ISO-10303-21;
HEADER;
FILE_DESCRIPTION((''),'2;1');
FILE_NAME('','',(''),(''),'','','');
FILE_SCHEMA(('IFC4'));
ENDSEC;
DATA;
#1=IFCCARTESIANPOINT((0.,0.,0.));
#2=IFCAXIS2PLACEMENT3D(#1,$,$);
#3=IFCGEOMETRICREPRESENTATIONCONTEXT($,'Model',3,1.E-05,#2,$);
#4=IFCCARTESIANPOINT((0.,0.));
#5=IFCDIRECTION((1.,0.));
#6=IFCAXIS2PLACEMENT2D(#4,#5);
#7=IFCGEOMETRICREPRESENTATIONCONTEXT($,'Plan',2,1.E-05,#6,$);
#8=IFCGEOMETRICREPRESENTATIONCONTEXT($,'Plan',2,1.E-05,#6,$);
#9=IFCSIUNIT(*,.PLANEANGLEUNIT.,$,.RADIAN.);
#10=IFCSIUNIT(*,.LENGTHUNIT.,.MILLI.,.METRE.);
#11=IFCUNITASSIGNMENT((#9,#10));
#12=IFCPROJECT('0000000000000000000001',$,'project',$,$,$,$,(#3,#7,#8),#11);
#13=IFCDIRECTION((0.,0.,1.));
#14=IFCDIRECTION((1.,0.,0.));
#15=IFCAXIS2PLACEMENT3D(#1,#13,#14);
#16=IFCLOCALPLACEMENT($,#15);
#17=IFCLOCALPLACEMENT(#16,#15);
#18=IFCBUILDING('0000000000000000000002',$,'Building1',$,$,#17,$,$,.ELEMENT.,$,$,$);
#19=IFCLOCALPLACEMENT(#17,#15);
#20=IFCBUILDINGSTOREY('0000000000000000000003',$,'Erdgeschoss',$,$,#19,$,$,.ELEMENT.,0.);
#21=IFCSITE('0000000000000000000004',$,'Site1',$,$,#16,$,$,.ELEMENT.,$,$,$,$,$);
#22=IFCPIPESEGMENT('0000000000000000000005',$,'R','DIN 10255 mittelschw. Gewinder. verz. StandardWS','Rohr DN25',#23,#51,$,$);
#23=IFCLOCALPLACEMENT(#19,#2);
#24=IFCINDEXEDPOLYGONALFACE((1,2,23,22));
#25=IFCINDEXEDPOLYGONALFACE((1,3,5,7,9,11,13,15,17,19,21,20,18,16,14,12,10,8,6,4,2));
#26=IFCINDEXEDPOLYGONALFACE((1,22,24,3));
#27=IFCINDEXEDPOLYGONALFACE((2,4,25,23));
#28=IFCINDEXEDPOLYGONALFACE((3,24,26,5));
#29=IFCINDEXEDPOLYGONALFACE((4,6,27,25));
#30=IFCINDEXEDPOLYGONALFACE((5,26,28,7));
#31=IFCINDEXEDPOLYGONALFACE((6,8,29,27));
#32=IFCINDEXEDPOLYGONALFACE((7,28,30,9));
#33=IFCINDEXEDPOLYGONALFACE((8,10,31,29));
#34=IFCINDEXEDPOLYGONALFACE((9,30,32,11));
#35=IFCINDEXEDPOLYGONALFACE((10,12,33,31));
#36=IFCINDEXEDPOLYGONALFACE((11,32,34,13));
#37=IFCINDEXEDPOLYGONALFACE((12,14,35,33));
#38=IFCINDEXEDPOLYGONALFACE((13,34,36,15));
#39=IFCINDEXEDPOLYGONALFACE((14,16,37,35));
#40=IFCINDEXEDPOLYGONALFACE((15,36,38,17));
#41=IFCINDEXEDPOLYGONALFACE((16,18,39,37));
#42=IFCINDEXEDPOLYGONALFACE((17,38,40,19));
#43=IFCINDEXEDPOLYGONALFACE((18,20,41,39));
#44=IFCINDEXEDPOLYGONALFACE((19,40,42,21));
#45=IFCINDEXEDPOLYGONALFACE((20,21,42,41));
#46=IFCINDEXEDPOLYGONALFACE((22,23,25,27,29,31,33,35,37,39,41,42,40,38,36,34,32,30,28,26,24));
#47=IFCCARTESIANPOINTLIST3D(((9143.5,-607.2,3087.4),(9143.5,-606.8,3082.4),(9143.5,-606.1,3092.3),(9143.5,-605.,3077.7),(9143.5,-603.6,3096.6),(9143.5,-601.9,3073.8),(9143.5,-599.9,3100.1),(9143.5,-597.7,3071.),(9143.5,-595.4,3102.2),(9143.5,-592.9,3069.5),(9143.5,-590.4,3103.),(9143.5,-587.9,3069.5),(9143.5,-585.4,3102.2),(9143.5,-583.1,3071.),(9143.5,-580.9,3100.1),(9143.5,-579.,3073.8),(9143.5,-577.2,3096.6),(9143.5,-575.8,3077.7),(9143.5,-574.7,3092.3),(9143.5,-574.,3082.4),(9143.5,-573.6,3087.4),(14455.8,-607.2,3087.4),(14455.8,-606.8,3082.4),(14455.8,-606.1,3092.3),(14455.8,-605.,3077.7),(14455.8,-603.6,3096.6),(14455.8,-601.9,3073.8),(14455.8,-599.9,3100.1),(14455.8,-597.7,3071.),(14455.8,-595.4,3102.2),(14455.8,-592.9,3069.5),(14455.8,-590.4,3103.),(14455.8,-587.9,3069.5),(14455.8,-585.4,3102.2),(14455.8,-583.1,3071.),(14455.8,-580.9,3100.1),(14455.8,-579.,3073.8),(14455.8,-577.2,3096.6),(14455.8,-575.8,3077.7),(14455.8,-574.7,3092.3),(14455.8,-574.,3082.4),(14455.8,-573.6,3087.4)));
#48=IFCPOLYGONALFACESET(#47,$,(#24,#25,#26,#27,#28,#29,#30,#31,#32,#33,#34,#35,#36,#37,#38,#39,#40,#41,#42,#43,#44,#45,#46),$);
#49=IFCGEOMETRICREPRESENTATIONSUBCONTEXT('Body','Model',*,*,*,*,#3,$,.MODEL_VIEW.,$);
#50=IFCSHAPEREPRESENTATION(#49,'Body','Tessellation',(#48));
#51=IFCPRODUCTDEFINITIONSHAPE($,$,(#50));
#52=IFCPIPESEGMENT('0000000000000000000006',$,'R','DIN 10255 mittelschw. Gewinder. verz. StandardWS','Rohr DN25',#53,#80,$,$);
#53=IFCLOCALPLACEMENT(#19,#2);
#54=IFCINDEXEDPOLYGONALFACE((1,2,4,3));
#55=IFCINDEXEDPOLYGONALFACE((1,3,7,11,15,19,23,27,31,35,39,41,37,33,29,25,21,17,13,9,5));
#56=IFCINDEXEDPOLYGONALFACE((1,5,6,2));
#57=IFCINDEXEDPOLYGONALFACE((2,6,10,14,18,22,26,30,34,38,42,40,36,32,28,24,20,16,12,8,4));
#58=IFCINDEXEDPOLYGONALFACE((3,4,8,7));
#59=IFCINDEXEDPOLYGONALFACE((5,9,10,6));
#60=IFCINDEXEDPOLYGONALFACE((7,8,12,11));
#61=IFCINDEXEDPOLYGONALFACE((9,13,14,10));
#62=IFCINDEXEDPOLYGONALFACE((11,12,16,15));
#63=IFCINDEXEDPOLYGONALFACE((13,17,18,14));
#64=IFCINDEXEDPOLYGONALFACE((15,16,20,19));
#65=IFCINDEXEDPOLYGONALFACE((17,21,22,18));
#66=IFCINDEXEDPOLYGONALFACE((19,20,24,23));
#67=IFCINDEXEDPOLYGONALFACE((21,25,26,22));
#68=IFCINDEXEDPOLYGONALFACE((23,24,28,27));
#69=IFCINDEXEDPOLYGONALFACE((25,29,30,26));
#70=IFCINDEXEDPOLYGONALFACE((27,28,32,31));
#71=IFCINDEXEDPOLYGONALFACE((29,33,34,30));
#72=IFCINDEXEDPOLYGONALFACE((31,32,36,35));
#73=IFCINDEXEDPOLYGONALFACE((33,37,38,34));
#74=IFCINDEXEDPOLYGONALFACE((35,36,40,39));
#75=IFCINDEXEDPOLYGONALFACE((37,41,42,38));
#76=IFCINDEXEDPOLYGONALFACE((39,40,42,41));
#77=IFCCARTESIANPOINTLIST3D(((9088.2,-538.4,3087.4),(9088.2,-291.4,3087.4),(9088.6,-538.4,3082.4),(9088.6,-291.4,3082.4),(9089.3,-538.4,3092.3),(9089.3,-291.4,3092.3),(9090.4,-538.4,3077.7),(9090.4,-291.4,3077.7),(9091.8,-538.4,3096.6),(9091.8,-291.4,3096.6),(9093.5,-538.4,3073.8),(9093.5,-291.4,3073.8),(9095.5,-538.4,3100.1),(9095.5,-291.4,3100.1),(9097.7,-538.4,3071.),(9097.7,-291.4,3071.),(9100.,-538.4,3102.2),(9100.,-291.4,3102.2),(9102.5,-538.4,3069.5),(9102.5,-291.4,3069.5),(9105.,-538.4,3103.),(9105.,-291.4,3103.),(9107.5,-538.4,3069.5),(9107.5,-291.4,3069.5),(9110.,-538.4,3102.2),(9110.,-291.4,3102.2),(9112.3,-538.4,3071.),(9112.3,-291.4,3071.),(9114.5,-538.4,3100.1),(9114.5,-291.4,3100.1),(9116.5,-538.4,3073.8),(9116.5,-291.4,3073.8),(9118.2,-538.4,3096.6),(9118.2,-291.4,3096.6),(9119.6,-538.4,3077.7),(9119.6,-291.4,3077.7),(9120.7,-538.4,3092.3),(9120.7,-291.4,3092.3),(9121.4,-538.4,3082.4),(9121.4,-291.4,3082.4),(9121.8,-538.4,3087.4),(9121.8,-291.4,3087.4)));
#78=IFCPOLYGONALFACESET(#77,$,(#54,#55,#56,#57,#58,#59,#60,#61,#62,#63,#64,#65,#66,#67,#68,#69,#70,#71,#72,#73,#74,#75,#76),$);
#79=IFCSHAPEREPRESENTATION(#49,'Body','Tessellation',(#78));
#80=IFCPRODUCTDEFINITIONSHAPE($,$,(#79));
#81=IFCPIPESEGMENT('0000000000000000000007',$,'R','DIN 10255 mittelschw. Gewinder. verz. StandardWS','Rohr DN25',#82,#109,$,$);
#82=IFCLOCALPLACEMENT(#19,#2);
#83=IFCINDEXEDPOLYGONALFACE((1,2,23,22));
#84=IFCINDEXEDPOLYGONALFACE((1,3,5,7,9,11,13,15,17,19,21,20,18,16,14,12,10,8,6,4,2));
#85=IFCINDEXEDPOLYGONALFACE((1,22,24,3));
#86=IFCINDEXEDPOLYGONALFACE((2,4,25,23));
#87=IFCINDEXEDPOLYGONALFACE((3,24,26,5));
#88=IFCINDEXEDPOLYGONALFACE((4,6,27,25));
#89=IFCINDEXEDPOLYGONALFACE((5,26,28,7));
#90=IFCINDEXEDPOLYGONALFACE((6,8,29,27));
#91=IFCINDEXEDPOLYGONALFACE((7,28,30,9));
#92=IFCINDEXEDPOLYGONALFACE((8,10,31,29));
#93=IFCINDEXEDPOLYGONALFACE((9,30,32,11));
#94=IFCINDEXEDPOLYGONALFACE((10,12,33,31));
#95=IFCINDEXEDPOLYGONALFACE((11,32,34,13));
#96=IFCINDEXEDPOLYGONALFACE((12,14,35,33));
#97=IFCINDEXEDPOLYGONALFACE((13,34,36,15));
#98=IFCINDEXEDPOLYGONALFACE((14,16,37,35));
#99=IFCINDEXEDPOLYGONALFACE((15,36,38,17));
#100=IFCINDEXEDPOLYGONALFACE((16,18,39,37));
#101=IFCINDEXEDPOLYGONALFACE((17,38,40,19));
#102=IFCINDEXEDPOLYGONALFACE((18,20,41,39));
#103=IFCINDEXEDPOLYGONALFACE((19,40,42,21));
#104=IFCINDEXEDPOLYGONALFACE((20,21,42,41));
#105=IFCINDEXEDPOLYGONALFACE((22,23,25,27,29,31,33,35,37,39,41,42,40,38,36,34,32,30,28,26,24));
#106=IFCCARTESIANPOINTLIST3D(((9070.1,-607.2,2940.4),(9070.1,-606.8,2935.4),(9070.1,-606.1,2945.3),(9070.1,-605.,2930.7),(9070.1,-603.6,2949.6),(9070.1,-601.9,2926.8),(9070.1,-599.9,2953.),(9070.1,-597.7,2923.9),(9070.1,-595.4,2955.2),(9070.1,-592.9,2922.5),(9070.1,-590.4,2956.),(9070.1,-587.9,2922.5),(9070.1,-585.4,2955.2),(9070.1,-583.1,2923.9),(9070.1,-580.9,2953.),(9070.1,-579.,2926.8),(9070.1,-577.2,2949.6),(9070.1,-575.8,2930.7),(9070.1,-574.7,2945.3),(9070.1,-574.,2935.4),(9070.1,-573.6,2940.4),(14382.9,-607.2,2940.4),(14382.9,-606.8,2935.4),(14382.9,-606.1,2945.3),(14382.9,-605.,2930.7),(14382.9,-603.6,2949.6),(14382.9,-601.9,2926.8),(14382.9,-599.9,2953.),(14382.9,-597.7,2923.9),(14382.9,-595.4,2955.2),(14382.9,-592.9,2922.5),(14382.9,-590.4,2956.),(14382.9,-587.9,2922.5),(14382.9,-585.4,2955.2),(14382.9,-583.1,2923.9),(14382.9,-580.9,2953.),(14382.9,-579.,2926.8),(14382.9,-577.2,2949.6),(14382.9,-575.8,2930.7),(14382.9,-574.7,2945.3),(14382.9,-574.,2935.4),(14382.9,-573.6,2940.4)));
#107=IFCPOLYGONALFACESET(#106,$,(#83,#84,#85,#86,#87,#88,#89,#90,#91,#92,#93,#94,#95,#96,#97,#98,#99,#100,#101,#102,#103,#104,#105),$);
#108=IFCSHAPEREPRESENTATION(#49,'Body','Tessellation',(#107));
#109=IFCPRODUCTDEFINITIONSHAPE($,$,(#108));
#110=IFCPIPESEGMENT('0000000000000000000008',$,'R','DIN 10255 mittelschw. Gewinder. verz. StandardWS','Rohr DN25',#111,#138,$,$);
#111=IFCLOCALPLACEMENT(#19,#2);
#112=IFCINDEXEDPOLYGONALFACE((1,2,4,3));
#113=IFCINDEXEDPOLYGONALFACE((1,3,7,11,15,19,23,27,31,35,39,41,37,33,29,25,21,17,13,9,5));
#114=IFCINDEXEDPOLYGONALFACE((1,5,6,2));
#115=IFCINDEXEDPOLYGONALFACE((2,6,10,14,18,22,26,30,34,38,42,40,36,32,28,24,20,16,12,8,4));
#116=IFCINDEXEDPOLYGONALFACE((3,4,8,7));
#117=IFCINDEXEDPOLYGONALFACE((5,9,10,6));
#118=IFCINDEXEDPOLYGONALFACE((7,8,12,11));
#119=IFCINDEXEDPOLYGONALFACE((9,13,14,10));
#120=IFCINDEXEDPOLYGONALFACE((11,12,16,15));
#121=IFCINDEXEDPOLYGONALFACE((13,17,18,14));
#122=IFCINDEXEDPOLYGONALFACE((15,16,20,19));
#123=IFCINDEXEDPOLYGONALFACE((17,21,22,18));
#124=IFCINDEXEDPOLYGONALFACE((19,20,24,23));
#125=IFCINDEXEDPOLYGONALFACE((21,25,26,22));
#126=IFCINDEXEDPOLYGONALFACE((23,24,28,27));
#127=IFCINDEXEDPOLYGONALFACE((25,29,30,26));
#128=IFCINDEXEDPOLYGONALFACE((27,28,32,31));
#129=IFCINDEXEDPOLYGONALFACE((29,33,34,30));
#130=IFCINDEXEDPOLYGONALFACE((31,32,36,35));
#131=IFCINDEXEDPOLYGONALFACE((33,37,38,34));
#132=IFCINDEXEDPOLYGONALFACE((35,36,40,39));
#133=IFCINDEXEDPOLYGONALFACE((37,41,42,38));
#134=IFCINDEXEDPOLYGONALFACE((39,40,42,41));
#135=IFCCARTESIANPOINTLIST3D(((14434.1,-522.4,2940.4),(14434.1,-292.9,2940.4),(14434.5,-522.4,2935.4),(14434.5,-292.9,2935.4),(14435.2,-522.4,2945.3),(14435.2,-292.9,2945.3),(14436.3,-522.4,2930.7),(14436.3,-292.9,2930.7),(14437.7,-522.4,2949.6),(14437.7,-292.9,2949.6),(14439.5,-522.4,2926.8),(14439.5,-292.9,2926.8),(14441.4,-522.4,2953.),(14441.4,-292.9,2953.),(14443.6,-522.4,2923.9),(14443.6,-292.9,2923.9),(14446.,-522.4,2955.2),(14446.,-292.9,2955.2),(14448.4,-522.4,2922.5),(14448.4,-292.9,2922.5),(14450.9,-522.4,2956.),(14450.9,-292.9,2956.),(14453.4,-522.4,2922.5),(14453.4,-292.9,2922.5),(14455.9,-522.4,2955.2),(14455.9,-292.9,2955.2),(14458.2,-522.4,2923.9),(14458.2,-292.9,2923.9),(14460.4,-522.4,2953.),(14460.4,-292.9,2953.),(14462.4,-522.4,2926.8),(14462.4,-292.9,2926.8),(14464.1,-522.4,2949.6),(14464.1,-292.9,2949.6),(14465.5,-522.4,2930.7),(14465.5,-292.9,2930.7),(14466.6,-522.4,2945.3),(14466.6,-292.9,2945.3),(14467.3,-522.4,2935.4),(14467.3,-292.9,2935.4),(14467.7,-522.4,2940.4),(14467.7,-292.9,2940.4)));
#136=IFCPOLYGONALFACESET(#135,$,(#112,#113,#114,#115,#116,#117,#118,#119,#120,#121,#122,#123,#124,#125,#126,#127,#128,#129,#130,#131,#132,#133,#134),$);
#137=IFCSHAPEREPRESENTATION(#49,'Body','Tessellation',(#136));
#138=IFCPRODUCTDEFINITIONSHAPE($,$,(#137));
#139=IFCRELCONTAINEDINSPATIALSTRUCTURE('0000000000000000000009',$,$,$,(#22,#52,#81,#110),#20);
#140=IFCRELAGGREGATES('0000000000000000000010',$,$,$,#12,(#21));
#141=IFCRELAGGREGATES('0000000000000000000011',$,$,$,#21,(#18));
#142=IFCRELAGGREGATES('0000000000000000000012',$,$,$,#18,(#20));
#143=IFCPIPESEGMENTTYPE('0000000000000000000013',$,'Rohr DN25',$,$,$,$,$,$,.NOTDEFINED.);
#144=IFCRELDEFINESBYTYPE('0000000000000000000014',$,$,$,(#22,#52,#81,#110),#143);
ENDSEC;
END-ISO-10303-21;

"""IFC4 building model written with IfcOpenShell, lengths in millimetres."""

from ifc_helpers import new_model, si_unit, frame, origin, origin_with_axes, origin_2d_with_axis, place, context, subcontext, project, spatial, circle, extrude, type_object, element, save


model = new_model("IFC4")

# Units and contexts
model_context = context("Model", 3, precision=1e-05, world=origin())
plan_context_1 = context("Plan", 2, precision=1e-05, world=origin_2d_with_axis())
plan_context_2 = context("Plan", 2, precision=1e-05, world=origin_2d_with_axis())
body_context = subcontext(model_context, "Body", "Model", "MODEL_VIEW")
ifc_project = project(units=[si_unit("PLANEANGLEUNIT", "RADIAN"), si_unit("LENGTHUNIT", "METRE", prefix="MILLI")], contexts=[model_context, plan_context_1, plan_context_2])

# Site, building, storey
site_placement = place(None, origin_with_axes())
site = spatial("IfcSite", under=ifc_project, at=site_placement, Name="Site1", CompositionType="ELEMENT")
building_placement = place(site_placement, origin_with_axes())
building = spatial("IfcBuilding", under=site, at=building_placement, Name="Building1", CompositionType="ELEMENT")
storey_placement = place(building_placement, origin_with_axes())
storey = spatial("IfcBuildingStorey", under=building, at=storey_placement, Name="Erdgeschoss", CompositionType="ELEMENT", Elevation=0.0)

# Pipe segments
pipe_segment_type_1 = type_object("IfcPipeSegmentType", Name="Rohr DN25", PredefinedType="NOTDEFINED")
pipe_segment_1_placement = place(storey_placement, frame((11799.6, -590.3, 3086.1), z_axis=(0.0, 0.0, 1.0), x_axis=(1.0, 0.0, 0.0)))
element("IfcPipeSegment", 1, at=pipe_segment_1_placement, inside=storey, type_object=pipe_segment_type_1, Name="R", Description="DIN 10255 mittelschw. Gewinder. verz. StandardWS", ObjectType="Rohr DN25", context=body_context, shape_type="SolidModel", body=[
    extrude(circle(Radius=16.9, at=origin_2d_with_axis()), frame((-2656.1, -0.2, 0.0), z_axis=(1.0, 0.0, 0.0), x_axis=(0.0, 0.0, 1.0)), (0.0, 0.0, 1.0), 5312.3),
])
pipe_segment_2_placement = place(storey_placement, frame((9104.8, -414.9, 3086.1), z_axis=(0.0, 0.0, 1.0), x_axis=(1.0, 0.0, 0.0)))
element("IfcPipeSegment", 2, at=pipe_segment_2_placement, inside=storey, type_object=pipe_segment_type_1, Name="R", Description="DIN 10255 mittelschw. Gewinder. verz. StandardWS", ObjectType="Rohr DN25", context=body_context, shape_type="SolidModel", body=[
    extrude(circle(Radius=16.9, at=origin_2d_with_axis()), frame((0.1, -123.5, 0.0), z_axis=(0.0, 1.0, 0.0), x_axis=(0.0, 0.0, 1.0)), (0.0, 0.0, 1.0), 247.0),
])
pipe_segment_3_placement = place(storey_placement, frame((11726.5, -590.3, 2939.1), z_axis=(0.0, 0.0, 1.0), x_axis=(1.0, 0.0, 0.0)))
element("IfcPipeSegment", 3, at=pipe_segment_3_placement, inside=storey, type_object=pipe_segment_type_1, Name="R", Description="DIN 10255 mittelschw. Gewinder. verz. StandardWS", ObjectType="Rohr DN25", context=body_context, shape_type="SolidModel", body=[
    extrude(circle(Radius=16.9, at=origin_2d_with_axis()), frame((-2656.4, -0.2, 0.0), z_axis=(1.0, 0.0, 0.0), x_axis=(0.0, 0.0, 1.0)), (0.0, 0.0, 1.0), 5312.8),
])
pipe_segment_4_placement = place(storey_placement, frame((14450.8, -407.6, 2939.1), z_axis=(0.0, 0.0, 1.0), x_axis=(1.0, 0.0, 0.0)))
element("IfcPipeSegment", 4, at=pipe_segment_4_placement, inside=storey, type_object=pipe_segment_type_1, Name="R", Description="DIN 10255 mittelschw. Gewinder. verz. StandardWS", ObjectType="Rohr DN25", context=body_context, shape_type="SolidModel", body=[
    extrude(circle(Radius=16.9, at=origin_2d_with_axis()), frame((0.2, -114.8, 0.0), z_axis=(-0.000001, 1.0, 0.0), x_axis=(0.0, 0.0, 1.0)), (0.0, 0.0, 1.0), 229.5),
])

save(model, "model.ifc")
